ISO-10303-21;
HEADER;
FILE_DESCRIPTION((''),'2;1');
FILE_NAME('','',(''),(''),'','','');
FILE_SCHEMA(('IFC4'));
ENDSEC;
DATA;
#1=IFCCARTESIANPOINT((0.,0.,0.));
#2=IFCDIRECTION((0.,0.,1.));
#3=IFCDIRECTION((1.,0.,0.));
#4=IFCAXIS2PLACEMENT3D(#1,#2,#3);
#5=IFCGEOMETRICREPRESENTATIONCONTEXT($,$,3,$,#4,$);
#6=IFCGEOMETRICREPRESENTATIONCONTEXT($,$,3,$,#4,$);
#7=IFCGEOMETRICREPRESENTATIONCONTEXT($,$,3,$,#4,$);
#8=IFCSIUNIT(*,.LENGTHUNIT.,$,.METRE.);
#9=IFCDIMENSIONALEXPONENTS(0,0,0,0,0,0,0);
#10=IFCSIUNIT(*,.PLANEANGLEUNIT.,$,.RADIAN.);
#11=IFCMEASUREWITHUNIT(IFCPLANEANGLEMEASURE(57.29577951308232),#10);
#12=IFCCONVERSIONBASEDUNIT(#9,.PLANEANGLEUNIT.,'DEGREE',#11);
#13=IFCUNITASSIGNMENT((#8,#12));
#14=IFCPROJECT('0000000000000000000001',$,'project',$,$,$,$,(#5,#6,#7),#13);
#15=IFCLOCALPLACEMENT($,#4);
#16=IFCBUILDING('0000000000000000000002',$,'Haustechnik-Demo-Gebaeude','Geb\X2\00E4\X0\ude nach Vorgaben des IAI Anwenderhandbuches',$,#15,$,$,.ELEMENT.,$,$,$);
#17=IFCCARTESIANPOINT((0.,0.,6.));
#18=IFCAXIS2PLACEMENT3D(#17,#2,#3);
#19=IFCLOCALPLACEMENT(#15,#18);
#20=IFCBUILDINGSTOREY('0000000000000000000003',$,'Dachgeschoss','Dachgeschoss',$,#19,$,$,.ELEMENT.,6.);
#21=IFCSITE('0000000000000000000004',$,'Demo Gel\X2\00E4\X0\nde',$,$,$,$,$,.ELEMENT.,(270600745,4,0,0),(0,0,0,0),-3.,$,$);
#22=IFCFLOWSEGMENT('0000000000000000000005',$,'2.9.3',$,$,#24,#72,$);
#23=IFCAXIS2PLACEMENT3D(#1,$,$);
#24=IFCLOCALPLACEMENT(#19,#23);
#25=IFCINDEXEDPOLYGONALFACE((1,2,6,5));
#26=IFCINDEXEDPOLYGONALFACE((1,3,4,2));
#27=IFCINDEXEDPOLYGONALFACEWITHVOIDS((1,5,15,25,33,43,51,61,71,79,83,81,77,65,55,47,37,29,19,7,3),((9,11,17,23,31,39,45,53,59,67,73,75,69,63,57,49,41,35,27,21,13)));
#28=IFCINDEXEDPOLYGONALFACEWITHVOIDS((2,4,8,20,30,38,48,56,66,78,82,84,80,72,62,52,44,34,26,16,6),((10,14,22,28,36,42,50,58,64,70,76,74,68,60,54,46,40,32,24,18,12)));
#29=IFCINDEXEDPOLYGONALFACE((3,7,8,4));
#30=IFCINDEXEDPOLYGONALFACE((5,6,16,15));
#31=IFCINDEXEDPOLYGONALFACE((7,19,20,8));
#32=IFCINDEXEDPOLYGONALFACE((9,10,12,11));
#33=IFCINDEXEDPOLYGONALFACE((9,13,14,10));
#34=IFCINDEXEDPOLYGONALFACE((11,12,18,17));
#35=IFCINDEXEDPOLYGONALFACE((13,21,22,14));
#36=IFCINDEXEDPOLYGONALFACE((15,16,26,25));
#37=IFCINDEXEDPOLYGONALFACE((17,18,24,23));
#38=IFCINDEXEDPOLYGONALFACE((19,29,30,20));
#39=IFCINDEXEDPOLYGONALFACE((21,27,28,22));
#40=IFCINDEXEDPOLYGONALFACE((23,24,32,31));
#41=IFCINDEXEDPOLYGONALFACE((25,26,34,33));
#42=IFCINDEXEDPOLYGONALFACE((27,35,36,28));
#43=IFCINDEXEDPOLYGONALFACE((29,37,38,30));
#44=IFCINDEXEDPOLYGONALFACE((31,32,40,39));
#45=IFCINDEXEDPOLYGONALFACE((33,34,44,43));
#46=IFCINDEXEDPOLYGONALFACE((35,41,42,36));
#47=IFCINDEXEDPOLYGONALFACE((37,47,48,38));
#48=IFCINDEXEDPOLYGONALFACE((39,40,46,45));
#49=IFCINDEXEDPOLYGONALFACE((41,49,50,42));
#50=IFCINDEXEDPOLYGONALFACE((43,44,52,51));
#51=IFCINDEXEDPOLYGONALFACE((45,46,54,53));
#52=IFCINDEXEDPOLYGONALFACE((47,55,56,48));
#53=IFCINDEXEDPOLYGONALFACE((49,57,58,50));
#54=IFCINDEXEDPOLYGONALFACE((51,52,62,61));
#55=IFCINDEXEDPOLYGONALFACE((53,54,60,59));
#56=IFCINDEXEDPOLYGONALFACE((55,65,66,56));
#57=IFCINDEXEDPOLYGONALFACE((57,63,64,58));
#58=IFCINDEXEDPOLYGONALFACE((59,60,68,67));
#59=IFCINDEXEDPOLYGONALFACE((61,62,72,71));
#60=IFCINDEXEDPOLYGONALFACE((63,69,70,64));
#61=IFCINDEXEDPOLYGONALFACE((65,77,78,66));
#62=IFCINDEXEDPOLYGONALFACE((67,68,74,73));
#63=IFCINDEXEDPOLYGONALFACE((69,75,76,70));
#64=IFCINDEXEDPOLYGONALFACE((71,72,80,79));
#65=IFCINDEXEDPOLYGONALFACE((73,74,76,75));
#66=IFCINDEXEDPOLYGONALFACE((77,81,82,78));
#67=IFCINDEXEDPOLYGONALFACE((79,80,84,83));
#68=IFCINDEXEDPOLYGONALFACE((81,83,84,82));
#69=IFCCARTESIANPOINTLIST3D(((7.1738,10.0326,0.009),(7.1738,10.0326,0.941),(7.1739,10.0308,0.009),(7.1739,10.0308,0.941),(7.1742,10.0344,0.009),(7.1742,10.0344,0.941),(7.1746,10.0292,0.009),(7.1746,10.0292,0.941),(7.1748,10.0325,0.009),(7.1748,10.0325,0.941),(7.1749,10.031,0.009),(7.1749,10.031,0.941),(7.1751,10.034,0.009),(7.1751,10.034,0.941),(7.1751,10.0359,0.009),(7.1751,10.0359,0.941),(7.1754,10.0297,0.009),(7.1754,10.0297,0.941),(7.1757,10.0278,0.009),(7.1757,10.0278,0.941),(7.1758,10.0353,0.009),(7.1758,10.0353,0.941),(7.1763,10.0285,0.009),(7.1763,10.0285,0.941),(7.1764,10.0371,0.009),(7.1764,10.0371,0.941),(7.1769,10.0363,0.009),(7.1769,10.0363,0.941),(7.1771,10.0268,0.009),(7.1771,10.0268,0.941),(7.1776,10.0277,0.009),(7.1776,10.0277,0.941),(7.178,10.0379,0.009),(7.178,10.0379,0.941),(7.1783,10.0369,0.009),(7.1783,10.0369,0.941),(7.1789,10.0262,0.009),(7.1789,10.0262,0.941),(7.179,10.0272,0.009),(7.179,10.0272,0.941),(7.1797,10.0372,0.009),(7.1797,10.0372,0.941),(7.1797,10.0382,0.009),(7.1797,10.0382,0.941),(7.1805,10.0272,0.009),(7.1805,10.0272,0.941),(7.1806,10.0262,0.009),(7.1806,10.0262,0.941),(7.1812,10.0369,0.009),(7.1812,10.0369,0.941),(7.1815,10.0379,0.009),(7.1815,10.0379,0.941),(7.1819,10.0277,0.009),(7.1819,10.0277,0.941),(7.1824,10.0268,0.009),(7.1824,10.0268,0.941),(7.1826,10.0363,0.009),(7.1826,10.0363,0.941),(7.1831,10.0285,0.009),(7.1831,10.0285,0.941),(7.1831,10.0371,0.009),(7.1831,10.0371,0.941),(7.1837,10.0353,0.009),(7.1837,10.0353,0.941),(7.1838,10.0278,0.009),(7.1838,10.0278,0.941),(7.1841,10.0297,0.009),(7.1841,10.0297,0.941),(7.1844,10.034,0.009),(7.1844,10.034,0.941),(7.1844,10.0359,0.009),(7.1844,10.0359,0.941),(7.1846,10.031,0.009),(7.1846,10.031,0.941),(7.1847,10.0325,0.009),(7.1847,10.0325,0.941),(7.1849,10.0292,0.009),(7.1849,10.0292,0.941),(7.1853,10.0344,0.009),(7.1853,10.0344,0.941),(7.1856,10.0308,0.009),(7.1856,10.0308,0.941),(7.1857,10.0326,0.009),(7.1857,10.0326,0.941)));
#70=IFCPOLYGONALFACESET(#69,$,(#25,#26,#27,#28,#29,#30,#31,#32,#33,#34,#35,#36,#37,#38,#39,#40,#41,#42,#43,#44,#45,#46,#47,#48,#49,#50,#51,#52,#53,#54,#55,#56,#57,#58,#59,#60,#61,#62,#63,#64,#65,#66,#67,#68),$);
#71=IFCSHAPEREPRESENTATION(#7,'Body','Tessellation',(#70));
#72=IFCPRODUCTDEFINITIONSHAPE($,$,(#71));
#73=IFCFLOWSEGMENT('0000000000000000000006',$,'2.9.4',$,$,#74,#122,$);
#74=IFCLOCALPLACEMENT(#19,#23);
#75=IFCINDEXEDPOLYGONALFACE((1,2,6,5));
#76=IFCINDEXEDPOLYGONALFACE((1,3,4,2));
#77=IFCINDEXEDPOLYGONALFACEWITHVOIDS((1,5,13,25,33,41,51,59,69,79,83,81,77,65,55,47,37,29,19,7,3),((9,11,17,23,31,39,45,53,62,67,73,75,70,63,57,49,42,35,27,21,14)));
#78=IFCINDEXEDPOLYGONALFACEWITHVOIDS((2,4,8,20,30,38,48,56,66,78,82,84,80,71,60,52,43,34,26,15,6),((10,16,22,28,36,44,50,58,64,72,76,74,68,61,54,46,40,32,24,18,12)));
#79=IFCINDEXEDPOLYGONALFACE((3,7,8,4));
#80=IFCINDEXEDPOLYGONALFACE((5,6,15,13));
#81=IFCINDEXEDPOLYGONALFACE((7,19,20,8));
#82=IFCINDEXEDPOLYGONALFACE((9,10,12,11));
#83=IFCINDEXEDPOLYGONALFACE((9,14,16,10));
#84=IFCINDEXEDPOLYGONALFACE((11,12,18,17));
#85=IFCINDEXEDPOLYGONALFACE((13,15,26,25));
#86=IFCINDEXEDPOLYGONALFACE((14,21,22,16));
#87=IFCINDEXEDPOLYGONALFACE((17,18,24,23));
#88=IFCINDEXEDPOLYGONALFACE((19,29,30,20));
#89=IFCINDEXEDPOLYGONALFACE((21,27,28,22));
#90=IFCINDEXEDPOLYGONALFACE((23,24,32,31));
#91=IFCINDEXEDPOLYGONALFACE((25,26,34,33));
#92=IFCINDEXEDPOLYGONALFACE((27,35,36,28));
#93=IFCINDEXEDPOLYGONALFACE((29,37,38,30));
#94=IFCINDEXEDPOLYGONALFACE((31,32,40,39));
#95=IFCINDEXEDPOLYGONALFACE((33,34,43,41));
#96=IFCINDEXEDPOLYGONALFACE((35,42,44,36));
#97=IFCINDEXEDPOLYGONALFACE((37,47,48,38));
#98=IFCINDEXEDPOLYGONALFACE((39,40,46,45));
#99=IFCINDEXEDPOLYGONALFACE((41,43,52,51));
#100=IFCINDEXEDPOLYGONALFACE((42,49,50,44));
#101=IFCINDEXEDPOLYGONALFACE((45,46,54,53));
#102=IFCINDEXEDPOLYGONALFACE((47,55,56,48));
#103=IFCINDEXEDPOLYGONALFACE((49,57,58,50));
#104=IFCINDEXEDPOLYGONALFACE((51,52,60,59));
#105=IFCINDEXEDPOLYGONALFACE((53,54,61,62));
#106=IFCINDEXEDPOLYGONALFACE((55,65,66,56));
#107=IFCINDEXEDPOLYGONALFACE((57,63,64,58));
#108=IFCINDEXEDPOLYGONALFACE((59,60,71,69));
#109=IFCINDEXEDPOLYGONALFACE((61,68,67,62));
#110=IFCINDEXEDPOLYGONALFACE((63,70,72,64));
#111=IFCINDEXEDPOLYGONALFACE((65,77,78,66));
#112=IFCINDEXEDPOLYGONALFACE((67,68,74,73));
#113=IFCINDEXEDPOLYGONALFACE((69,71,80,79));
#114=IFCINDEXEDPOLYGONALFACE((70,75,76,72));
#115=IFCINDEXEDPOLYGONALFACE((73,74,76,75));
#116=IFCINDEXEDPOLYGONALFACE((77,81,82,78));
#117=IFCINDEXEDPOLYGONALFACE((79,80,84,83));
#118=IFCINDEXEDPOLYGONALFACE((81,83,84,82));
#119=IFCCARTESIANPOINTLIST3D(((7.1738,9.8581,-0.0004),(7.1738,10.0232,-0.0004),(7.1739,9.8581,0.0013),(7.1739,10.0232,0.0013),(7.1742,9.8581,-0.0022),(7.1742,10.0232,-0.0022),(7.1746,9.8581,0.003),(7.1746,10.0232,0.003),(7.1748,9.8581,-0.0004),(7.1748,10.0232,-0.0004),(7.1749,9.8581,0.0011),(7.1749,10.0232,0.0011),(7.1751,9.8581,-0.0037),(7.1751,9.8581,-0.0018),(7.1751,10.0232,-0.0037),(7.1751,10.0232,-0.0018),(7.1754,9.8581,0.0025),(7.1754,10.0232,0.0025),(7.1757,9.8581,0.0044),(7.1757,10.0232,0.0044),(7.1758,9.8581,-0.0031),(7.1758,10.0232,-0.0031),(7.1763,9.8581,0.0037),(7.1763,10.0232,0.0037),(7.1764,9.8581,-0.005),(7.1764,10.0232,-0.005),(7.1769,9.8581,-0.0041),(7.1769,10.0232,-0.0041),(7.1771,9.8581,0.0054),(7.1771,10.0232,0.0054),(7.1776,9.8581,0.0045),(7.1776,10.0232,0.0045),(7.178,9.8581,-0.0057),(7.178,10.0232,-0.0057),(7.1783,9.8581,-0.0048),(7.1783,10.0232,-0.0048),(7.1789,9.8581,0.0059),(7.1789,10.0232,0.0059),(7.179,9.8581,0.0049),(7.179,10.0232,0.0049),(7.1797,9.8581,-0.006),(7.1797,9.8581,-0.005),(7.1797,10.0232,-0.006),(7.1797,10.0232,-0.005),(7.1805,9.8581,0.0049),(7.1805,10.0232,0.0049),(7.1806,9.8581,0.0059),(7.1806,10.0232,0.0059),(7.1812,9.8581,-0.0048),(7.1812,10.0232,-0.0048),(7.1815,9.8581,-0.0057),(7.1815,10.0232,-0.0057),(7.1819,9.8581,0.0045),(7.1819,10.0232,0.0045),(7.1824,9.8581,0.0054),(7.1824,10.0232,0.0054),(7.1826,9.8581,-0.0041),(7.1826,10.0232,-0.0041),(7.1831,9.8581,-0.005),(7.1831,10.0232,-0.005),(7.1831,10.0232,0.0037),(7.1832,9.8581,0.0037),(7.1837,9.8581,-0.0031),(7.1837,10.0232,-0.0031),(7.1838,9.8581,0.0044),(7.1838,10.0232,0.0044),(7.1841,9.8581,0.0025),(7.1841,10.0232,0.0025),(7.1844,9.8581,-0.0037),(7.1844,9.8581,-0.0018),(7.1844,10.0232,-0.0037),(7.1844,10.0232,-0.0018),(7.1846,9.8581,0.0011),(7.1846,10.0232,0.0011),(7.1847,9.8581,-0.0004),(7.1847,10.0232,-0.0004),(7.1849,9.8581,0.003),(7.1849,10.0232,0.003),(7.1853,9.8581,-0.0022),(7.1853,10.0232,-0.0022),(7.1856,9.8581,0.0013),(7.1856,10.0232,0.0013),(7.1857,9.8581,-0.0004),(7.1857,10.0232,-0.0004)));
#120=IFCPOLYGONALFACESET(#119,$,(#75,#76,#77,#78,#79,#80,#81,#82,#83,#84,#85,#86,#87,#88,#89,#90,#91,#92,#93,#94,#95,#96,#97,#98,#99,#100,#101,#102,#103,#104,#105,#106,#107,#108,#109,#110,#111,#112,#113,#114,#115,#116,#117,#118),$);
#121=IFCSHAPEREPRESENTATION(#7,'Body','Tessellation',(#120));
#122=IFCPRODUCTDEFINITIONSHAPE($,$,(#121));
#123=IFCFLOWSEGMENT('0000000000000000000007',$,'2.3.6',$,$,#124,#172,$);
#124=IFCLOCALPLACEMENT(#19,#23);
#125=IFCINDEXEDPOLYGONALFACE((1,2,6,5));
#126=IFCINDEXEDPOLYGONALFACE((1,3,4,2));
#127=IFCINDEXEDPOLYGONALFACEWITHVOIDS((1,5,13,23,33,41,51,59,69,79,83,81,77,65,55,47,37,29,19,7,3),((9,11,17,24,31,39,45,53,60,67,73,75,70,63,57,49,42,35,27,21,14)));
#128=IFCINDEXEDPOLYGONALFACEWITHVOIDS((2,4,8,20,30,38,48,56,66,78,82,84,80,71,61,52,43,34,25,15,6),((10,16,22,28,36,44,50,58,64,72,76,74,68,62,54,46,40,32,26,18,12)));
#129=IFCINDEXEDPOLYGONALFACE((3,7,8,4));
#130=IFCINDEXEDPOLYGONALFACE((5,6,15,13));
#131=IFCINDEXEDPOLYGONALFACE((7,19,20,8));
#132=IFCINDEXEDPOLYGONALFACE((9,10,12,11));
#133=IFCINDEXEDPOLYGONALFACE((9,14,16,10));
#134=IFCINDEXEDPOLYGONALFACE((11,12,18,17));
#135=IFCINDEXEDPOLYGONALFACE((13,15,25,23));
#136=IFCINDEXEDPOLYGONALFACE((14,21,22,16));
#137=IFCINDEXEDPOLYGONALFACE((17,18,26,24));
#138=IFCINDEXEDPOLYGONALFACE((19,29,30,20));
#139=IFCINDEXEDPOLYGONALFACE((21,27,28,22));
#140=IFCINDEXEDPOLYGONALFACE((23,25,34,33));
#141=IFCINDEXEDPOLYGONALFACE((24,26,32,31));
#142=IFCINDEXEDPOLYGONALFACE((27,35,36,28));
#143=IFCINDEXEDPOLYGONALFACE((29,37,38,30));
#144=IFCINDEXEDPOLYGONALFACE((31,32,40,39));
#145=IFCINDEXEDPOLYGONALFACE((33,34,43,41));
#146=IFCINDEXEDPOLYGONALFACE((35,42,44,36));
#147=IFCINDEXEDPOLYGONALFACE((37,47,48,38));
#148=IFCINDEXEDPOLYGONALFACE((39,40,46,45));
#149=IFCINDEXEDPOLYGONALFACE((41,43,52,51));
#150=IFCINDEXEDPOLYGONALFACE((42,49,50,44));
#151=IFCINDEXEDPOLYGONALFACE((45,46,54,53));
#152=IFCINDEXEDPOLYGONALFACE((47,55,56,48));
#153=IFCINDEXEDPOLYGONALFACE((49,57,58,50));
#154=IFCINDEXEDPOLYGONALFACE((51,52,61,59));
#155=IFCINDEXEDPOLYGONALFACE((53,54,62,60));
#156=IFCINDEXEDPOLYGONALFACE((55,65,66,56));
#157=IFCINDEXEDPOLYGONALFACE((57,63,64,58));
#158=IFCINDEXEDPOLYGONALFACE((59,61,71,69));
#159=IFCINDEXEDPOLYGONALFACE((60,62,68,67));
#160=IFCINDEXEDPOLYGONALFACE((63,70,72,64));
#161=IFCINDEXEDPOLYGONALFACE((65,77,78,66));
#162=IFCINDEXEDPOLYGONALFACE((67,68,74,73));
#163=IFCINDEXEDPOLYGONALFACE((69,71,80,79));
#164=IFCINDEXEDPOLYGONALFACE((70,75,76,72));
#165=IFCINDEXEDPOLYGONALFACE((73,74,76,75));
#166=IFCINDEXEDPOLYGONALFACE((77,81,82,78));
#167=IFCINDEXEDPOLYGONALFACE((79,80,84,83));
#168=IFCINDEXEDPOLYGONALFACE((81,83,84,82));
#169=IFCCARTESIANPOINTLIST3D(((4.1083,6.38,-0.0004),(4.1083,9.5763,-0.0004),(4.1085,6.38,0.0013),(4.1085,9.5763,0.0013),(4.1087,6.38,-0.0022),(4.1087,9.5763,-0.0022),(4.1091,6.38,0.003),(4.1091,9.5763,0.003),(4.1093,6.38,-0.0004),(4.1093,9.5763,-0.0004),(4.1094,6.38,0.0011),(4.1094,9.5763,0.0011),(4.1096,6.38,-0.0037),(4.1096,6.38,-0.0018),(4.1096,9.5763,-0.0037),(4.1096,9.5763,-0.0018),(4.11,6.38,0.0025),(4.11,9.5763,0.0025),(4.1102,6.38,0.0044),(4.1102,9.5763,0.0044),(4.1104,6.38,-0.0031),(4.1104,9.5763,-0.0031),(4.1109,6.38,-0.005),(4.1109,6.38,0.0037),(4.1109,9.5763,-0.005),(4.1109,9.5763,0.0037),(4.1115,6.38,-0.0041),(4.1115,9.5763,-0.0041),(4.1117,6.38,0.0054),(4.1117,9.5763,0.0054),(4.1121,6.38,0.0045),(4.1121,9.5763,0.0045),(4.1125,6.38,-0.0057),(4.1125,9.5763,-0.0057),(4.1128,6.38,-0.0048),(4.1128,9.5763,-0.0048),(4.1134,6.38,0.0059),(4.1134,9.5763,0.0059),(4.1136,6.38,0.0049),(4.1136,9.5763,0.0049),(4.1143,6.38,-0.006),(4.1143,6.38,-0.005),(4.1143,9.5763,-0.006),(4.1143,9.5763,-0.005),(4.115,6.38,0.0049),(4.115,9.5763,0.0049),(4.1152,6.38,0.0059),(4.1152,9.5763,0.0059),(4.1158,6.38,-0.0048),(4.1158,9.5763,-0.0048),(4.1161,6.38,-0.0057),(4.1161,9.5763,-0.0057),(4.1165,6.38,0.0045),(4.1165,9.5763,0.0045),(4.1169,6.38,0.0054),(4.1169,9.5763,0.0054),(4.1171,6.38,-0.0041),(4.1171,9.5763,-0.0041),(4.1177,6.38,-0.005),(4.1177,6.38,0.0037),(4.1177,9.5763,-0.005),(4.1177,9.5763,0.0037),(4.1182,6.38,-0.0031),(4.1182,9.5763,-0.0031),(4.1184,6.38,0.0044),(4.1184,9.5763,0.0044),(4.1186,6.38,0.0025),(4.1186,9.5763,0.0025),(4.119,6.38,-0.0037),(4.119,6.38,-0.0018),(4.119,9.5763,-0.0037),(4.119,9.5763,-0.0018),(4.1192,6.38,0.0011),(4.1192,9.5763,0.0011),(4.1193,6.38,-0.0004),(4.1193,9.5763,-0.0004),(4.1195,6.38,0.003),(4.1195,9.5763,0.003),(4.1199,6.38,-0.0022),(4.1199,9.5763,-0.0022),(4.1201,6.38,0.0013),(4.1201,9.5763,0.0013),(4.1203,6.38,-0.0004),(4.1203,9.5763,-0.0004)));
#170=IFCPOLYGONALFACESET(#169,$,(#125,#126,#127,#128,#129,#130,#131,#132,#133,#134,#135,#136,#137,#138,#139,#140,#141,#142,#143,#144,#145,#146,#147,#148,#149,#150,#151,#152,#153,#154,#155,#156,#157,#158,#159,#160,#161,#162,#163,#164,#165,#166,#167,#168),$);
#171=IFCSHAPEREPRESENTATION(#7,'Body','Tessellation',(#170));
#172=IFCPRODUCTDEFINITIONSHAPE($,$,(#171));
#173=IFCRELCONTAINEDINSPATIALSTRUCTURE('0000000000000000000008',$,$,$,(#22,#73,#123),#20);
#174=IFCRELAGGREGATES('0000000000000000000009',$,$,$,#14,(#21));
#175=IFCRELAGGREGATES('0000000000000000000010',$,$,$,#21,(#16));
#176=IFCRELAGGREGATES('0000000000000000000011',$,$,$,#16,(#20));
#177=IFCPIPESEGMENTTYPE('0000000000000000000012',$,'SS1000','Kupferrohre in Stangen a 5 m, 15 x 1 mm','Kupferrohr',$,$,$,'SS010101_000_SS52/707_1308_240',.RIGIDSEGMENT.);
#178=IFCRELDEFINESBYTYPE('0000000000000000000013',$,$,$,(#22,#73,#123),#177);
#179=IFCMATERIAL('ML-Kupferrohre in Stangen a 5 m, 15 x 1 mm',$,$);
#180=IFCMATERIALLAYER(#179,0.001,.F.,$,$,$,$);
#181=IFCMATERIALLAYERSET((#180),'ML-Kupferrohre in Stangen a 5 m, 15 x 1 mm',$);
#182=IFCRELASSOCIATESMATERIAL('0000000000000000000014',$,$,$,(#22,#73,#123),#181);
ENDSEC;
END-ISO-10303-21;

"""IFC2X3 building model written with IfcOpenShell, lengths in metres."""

from ifc_helpers import new_model, entity, si_unit, converted_unit, frame, origin_with_axes, origin_2d_with_axis, place, context, project, spatial, hollow_circle, extrude, material, layer, layer_set, layer_usage, type_object, element, save


model = new_model("IFC2X3")

# Units and contexts
context_of_model_1 = context(None, 3, world=origin_with_axes())
context_of_model_2 = context(None, 3, world=origin_with_axes())
context_of_model_3 = context(None, 3, world=origin_with_axes())
ifc_project = project(units=[si_unit("LENGTHUNIT", "METRE"), converted_unit("PLANEANGLEUNIT", "DEGREE", entity("IfcPlaneAngleMeasure", 57.29577951308232), si_unit("PLANEANGLEUNIT", "RADIAN"), dimensions=[0, 0, 0, 0, 0, 0, 0])], contexts=[context_of_model_1, context_of_model_2, context_of_model_3])

# Site, building, storey
site = spatial("IfcSite", under=ifc_project, Name="Demo Gelände", CompositionType="ELEMENT", RefLatitude=(270600745, 4, 0, 0), RefLongitude=(0, 0, 0, 0), RefElevation=-3.0)
building_placement = place(None, origin_with_axes())
building = spatial("IfcBuilding", under=site, at=building_placement, Name="Haustechnik-Demo-Gebaeude", Description="Gebäude nach Vorgaben des IAI Anwenderhandbuches", CompositionType="ELEMENT")
storey_placement = place(building_placement, frame((0.0, 0.0, 6.0), z_axis=(0.0, 0.0, 1.0), x_axis=(1.0, 0.0, 0.0)))
storey = spatial("IfcBuildingStorey", under=building, at=storey_placement, Name="Dachgeschoss", Description="Dachgeschoss", CompositionType="ELEMENT", Elevation=6.0)

# Flow segments
ifc_material = material(Name="ML-Kupferrohre in Stangen a 5 m, 15 x 1 mm")
ifc_layer = layer(ifc_material, 0.001, ventilated=False)
ifc_layer_set = layer_set([ifc_layer], Name="ML-Kupferrohre in Stangen a 5 m, 15 x 1 mm")
ifc_layer_usage = layer_usage(ifc_layer_set, "AXIS2", "POSITIVE", 0.0)
pipe_segment_type_1 = type_object("IfcPipeSegmentType", Name="SS1000", Description="Kupferrohre in Stangen a 5 m, 15 x 1 mm", ApplicableOccurrence="Kupferrohr", ElementType="SS010101_000_SS52/707_1308_240", PredefinedType="RIGIDSEGMENT")
flow_segment_1_placement = place(storey_placement, frame((7.1797, 10.0322, 0.941), z_axis=(0.0, 0.0, -1.0), x_axis=(0.0, 1.0, 0.0)))
element("IfcFlowSegment", 1, at=flow_segment_1_placement, inside=storey, type_object=pipe_segment_type_1, material=ifc_layer_usage, Name="2.9.3", context=context_of_model_3, shape_type="SweptSolid", body=[
    extrude(hollow_circle(Radius=0.006, WallThickness=0.001, at=origin_2d_with_axis()), origin_with_axes(), (0.0, 0.0, 1.0), 0.932),
])
flow_segment_2_placement = place(storey_placement, frame((7.1797, 10.0232, 0.0), z_axis=(0.000004, -1.0, 0.0), x_axis=(0.0, 0.0, -1.0)))
element("IfcFlowSegment", 2, at=flow_segment_2_placement, inside=storey, type_object=pipe_segment_type_1, material=ifc_layer_usage, Name="2.9.4", context=context_of_model_3, shape_type="SweptSolid", body=[
    extrude(hollow_circle(Radius=0.006, WallThickness=0.001, at=origin_2d_with_axis()), origin_with_axes(), (0.0, 0.0, 1.0), 0.1651),
])
flow_segment_3_placement = place(storey_placement, frame((4.1143, 6.38, 0.0), z_axis=(0.0, 1.0, 0.0), x_axis=(0.0, 0.0, -1.0)))
element("IfcFlowSegment", 3, at=flow_segment_3_placement, inside=storey, type_object=pipe_segment_type_1, material=ifc_layer_usage, Name="2.3.6", context=context_of_model_3, shape_type="SweptSolid", body=[
    extrude(hollow_circle(Radius=0.006, WallThickness=0.001, at=origin_2d_with_axis()), origin_with_axes(), (0.0, 0.0, 1.0), 3.1963),
])

save(model, "model.ifc")
